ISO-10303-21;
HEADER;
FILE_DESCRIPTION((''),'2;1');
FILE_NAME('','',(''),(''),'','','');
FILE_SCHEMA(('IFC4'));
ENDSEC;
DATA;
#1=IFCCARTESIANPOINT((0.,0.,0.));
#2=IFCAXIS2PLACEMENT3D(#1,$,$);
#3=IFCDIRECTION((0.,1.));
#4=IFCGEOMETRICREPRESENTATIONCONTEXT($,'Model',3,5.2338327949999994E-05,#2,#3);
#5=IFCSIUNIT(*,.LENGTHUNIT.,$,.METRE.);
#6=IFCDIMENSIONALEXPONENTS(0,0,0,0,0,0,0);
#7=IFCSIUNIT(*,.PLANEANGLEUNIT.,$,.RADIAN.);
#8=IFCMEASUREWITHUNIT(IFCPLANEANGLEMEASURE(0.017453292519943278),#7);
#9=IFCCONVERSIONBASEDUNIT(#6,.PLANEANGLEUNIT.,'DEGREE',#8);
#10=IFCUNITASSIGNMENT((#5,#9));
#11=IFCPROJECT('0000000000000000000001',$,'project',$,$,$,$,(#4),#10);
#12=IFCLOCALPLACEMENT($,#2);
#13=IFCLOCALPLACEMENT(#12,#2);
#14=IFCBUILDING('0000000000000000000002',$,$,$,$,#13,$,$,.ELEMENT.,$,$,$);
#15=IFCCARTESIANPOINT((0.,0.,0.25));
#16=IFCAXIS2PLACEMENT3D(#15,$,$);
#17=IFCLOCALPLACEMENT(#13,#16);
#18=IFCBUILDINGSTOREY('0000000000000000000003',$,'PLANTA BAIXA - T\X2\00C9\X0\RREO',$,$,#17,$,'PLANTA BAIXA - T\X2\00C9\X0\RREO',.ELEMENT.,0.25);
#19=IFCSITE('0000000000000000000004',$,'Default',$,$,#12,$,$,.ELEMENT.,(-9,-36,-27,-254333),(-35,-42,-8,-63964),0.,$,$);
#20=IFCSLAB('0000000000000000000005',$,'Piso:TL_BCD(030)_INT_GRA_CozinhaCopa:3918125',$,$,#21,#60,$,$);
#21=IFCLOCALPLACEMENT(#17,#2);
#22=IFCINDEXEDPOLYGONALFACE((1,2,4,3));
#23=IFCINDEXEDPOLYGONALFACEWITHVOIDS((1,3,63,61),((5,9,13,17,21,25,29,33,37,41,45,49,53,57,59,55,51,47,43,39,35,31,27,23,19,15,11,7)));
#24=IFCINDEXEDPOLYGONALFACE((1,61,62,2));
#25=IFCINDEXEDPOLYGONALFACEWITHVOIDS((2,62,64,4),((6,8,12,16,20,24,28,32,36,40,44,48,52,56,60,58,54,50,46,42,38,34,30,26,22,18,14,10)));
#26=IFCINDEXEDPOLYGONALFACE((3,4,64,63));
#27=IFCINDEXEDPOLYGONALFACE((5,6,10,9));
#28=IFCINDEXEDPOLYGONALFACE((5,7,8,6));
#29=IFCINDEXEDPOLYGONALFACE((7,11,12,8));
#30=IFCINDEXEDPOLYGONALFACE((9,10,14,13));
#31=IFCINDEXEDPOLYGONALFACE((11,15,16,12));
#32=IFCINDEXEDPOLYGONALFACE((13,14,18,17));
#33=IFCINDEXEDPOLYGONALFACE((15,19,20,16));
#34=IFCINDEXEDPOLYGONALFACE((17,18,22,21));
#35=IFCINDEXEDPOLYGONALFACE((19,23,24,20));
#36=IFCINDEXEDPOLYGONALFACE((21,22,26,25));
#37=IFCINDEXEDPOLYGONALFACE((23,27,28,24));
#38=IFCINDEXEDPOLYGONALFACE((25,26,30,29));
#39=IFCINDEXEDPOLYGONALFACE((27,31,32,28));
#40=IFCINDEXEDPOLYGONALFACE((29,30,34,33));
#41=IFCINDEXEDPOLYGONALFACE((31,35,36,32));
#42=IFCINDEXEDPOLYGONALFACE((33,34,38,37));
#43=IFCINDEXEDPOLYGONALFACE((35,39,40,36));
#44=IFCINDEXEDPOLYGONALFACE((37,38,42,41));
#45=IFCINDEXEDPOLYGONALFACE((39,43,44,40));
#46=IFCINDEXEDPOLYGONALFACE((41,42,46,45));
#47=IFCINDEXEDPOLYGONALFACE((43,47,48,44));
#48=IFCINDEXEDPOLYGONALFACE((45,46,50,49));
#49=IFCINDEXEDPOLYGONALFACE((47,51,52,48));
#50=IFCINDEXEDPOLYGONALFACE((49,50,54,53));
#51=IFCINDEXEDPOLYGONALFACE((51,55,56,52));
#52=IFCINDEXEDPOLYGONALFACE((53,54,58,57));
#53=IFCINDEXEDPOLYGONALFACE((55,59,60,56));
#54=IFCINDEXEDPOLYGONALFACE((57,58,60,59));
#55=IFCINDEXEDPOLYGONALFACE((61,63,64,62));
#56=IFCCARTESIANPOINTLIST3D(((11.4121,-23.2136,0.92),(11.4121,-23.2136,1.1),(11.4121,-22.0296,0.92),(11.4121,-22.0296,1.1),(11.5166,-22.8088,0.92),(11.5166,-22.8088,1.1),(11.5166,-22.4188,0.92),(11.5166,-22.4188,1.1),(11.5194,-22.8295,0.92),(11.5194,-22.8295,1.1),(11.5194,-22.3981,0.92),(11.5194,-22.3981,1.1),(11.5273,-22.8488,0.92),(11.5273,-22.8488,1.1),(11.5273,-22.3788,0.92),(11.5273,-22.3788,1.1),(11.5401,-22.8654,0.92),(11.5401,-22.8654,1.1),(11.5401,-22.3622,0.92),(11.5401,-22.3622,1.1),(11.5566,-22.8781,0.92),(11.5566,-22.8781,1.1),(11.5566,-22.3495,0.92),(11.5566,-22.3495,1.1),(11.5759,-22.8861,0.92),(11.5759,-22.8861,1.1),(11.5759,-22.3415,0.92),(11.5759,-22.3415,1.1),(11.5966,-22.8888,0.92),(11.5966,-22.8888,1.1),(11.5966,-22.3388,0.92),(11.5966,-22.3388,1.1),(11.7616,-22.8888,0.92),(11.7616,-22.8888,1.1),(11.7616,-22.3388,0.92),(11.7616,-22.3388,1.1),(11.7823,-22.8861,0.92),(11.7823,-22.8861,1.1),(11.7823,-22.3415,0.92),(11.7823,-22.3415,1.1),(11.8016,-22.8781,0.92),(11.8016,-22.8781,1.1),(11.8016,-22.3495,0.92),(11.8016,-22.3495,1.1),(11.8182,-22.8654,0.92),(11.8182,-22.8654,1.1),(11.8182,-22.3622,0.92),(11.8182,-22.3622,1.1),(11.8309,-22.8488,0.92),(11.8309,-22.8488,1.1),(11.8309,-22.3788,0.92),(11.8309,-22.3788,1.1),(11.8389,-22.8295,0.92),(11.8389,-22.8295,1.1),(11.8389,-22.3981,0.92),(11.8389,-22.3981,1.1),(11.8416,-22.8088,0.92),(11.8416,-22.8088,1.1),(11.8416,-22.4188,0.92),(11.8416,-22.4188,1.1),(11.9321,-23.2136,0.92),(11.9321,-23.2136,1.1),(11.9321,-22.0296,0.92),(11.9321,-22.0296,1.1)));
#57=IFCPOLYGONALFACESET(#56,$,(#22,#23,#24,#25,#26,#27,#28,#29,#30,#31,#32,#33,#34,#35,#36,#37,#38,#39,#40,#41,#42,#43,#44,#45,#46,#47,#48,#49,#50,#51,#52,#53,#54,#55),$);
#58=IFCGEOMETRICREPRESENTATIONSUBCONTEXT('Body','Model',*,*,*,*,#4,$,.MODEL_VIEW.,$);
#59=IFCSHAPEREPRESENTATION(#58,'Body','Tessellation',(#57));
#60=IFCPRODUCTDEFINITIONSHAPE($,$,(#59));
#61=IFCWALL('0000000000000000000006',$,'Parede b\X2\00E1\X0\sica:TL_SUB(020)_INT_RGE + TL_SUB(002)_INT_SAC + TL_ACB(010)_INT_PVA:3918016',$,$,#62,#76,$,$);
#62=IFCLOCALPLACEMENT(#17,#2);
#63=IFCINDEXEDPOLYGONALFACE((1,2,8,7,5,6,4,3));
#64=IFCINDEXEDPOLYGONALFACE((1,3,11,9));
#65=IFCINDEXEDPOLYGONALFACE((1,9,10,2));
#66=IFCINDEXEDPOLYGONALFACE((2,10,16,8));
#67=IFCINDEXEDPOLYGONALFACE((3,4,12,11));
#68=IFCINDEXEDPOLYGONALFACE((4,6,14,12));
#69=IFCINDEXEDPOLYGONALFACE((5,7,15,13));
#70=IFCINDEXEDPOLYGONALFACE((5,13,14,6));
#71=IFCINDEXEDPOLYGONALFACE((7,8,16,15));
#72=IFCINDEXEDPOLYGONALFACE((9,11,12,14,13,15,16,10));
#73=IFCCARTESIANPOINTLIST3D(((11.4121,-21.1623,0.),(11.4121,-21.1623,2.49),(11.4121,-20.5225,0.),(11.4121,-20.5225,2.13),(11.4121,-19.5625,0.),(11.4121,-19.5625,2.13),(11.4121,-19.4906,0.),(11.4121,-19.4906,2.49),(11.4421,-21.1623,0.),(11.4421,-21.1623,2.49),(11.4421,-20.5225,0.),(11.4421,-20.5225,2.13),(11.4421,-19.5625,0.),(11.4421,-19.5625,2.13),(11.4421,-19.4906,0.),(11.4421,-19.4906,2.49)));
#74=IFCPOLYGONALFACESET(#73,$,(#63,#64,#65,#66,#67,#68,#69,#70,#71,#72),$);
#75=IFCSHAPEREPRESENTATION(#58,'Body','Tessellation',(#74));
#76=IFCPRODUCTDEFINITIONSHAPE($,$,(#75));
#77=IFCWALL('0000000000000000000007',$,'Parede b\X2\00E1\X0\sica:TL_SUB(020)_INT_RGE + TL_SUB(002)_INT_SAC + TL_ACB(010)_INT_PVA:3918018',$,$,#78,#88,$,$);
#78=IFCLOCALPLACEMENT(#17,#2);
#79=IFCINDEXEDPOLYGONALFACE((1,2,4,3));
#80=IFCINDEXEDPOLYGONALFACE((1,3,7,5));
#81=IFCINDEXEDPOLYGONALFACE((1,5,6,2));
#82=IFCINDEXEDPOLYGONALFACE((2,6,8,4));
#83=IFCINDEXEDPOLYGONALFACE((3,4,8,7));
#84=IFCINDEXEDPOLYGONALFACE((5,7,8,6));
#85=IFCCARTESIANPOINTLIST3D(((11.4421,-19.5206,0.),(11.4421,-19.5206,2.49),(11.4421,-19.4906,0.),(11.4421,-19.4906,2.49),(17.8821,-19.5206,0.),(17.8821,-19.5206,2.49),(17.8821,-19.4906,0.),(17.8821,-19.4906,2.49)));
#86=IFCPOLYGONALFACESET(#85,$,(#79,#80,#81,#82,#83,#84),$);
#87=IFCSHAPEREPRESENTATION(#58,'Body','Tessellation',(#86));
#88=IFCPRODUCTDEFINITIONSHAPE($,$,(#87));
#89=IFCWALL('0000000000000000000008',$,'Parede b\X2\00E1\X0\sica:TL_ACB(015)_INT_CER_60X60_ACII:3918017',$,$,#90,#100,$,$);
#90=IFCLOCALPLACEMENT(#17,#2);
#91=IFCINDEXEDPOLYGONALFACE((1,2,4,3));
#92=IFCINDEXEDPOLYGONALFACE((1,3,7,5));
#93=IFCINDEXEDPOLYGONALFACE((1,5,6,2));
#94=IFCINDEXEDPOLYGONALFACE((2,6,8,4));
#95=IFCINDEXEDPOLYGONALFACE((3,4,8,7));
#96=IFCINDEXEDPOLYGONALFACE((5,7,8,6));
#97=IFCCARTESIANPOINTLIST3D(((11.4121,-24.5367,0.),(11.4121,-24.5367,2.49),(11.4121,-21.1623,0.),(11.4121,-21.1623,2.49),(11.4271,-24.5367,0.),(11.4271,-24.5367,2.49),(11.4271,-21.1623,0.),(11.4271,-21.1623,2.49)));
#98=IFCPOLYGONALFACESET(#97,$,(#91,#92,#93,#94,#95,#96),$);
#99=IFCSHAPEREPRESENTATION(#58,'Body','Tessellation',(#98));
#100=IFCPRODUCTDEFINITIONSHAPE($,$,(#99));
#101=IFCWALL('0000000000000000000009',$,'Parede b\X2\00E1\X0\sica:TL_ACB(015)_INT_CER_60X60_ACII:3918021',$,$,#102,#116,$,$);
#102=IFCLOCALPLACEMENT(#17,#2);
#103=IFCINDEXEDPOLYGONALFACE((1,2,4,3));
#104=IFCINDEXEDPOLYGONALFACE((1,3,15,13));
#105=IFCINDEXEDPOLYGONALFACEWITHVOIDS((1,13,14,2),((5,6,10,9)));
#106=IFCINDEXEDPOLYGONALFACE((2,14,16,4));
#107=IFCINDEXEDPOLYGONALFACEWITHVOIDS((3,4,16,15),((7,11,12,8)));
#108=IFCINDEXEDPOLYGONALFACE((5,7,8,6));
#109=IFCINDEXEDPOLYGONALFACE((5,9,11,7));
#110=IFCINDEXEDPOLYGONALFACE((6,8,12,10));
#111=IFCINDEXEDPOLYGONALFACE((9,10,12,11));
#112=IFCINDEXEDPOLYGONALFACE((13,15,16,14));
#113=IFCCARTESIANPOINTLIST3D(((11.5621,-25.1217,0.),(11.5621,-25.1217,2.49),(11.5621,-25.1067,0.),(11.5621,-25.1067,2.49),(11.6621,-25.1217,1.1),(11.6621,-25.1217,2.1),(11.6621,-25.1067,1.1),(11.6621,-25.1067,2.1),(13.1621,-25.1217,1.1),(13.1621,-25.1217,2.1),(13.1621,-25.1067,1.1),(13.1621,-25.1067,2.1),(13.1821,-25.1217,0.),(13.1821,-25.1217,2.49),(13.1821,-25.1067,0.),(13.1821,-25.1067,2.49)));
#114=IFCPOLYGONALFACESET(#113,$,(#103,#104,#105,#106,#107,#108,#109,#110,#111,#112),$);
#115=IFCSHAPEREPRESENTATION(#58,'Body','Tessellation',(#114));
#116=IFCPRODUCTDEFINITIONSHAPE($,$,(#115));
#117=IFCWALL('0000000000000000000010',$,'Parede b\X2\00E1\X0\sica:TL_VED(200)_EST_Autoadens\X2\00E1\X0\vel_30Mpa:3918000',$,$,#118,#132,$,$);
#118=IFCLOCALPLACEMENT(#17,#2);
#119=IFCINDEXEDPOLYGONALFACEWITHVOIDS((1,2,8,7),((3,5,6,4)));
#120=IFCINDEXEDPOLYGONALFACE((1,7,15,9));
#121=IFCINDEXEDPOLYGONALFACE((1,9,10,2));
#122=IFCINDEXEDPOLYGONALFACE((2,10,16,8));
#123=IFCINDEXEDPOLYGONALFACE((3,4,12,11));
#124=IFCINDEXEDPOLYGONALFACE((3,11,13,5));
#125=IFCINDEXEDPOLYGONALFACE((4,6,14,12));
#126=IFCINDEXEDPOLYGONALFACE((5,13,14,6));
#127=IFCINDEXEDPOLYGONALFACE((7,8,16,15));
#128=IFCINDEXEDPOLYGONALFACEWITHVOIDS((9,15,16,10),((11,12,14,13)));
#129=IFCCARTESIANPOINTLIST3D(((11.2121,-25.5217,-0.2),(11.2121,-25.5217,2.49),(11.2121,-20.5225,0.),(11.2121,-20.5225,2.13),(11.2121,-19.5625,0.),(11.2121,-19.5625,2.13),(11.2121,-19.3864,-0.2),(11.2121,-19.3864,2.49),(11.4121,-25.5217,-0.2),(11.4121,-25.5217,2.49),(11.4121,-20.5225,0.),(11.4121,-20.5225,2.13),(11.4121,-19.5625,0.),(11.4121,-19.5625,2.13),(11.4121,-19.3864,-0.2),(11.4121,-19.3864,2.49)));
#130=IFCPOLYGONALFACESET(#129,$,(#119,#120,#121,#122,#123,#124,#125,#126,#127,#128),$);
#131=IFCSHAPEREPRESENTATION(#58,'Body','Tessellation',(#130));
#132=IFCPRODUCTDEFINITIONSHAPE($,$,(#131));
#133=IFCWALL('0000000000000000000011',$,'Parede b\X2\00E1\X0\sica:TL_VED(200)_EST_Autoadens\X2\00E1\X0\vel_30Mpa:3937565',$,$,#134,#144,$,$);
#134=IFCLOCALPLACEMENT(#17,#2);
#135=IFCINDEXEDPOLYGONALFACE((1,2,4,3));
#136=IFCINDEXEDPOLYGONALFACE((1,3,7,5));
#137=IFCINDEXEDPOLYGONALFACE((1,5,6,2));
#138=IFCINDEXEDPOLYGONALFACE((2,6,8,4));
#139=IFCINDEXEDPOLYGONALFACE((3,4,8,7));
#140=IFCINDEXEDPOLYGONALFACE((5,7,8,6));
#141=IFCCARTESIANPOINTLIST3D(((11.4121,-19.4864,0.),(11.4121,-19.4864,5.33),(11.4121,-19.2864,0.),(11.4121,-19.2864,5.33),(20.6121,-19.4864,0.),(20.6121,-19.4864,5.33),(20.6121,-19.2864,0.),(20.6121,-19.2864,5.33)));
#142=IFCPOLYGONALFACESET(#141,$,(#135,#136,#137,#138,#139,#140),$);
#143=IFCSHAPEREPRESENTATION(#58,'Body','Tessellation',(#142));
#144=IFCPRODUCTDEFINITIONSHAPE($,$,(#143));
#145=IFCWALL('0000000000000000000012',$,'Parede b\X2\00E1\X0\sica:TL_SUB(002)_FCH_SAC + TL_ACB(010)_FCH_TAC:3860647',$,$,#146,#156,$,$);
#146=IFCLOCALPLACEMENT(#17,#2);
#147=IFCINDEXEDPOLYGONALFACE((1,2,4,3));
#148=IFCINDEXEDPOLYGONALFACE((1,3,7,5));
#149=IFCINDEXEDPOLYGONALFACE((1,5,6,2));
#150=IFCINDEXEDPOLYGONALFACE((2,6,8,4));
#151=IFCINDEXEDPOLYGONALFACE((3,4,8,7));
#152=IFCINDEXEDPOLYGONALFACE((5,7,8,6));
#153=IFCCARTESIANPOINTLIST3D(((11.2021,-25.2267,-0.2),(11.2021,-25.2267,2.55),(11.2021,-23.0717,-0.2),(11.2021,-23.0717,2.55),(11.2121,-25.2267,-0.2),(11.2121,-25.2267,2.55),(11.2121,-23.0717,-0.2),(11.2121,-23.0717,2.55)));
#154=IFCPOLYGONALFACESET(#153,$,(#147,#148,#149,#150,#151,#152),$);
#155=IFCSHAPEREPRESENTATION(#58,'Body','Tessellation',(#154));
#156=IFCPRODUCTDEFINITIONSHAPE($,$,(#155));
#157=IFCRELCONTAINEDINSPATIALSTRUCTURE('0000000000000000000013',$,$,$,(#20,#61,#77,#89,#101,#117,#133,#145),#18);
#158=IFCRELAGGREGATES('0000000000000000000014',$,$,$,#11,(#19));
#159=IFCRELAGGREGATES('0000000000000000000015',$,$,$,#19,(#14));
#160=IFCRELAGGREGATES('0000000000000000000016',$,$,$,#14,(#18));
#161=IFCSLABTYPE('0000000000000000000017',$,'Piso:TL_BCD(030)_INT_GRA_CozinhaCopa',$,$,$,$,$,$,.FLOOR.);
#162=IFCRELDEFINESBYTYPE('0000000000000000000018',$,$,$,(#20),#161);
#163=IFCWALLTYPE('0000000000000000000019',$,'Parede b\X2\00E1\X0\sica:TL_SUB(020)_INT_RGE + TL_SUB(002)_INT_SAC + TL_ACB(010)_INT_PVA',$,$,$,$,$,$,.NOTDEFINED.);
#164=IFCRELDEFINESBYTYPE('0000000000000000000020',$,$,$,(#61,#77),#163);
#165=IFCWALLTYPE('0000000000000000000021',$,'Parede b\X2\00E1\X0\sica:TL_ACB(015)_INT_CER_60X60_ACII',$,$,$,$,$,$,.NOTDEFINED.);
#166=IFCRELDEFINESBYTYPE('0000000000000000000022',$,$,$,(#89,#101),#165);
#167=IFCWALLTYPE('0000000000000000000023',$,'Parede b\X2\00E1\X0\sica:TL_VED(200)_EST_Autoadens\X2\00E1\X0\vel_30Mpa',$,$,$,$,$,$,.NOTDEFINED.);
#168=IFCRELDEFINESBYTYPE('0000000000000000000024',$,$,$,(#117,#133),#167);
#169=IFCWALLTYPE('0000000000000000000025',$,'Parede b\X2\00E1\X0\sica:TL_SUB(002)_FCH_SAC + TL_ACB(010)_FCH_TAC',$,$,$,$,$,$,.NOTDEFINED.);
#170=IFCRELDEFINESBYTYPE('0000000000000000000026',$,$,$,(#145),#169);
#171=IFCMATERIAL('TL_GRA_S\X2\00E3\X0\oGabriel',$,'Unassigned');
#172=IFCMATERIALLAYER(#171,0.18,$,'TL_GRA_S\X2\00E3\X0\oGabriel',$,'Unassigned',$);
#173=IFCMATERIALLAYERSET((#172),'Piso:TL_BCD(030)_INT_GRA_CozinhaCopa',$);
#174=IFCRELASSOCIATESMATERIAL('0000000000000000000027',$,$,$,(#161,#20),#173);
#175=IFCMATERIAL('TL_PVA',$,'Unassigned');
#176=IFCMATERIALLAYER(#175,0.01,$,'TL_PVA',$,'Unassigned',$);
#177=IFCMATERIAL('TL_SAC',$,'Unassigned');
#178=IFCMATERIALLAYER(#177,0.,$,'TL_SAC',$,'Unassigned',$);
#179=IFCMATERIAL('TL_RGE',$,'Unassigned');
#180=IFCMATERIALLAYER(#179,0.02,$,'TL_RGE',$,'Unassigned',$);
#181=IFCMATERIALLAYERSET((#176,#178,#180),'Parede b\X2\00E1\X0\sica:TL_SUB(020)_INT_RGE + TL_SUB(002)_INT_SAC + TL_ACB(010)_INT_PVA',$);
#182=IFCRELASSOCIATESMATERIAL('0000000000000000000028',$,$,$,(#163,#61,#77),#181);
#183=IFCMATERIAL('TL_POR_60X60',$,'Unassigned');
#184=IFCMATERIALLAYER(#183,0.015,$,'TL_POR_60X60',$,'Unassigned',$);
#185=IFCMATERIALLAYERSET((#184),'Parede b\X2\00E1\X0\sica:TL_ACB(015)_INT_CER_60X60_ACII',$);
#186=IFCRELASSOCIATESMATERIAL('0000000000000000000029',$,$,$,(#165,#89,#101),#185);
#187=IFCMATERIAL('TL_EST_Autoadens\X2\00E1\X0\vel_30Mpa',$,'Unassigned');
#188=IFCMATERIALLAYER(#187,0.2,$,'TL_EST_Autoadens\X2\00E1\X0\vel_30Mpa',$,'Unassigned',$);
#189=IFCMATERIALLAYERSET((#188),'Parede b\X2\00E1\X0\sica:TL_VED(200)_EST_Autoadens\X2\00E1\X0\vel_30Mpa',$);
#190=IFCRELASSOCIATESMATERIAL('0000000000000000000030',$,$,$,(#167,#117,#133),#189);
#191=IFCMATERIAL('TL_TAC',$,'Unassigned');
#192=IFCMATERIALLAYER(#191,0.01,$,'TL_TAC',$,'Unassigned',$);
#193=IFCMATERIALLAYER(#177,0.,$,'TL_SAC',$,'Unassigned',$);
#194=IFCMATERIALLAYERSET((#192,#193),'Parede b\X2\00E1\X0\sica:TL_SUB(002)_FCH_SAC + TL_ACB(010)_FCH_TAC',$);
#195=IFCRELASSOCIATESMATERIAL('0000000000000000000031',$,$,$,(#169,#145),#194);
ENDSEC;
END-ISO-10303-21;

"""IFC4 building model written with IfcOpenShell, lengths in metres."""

from ifc_helpers import new_model, entity, si_unit, converted_unit, direction, frame, frame_2d, origin, place, context, subcontext, project, spatial, polyline, circle_curve, parameter, trimmed, segment, composite_curve, rectangle, outline, extrude, material, layer, layer_set, layer_usage, type_object, element, save


model = new_model("IFC4")

# Units and contexts
model_context = context("Model", 3, precision=5.2338327949999994e-05, world=origin(), true_north=direction((0.0, 1.0)))
body_context = subcontext(model_context, "Body", "Model", "MODEL_VIEW")
ifc_project = project(units=[si_unit("LENGTHUNIT", "METRE"), converted_unit("PLANEANGLEUNIT", "DEGREE", entity("IfcPlaneAngleMeasure", 0.017453292519943278), si_unit("PLANEANGLEUNIT", "RADIAN"), dimensions=[0, 0, 0, 0, 0, 0, 0])], contexts=[model_context])

# Site, building, storey
site_placement = place(None, frame((0.0, 0.0, 0.0)))
site = spatial("IfcSite", under=ifc_project, at=site_placement, Name="Default", CompositionType="ELEMENT", RefLatitude=(-9, -36, -27, -254333), RefLongitude=(-35, -42, -8, -63964), RefElevation=0.0)
building_placement = place(site_placement, origin())
building = spatial("IfcBuilding", under=site, at=building_placement, CompositionType="ELEMENT")
storey_placement = place(building_placement, frame((0.0, 0.0, 0.25)))
storey = spatial("IfcBuildingStorey", under=building, at=storey_placement, Name="PLANTA BAIXA - TÉRREO", LongName="PLANTA BAIXA - TÉRREO", CompositionType="ELEMENT", Elevation=0.25)

# Shared definitions
ifc_material_1 = material(Name="TL_POR_60X60", Category="Unassigned")

# Slab, opening
ifc_material_2 = material(Name="TL_GRA_SãoGabriel", Category="Unassigned")
ifc_layer_1 = layer(ifc_material_2, 0.18, Name="TL_GRA_SãoGabriel", Category="Unassigned")
ifc_layer_set_1 = layer_set([ifc_layer_1], Name="Piso:TL_BCD(030)_INT_GRA_CozinhaCopa")
ifc_layer_usage_1 = layer_usage(ifc_layer_set_1, "AXIS3", "POSITIVE", 0.0)
slab_type_1 = type_object("IfcSlabType", Name="Piso:TL_BCD(030)_INT_GRA_CozinhaCopa", PredefinedType="FLOOR", material=ifc_layer_set_1)
slab_1_placement = place(storey_placement, frame((11.4121, -23.2136, 0.92)))
slab_1 = element("IfcSlab", 1, at=slab_1_placement, inside=storey, type_object=slab_type_1, material=ifc_layer_usage_1, Name="Piso:TL_BCD(030)_INT_GRA_CozinhaCopa:3918125", context=body_context, shape_type="SweptSolid", body=[
    extrude(rectangle(XDim=1.184, YDim=0.52, at=frame_2d((0.0, 0.0), x_axis=(0.0, 1.0))), frame((0.26, 0.592, 0.18), z_axis=(0.0, 0.0, -1.0), x_axis=(-1.0, 0.0, 0.0)), (0.0, 0.0, 1.0), 0.18),
])
opening_1_placement = place(slab_1_placement, frame((-11.4121, 23.2136, 0.18)))
element("IfcOpeningElement", 2, at=opening_1_placement, cuts=slab_1, PredefinedType="OPENING", context=body_context, shape_type="SweptSolid", body=[
    extrude(outline(composite_curve([segment(polyline([(-0.195, -0.1625), (0.195, -0.1625)]), True, "CONTINUOUS"), segment(trimmed(circle_curve(frame_2d((0.195, -0.0825), x_axis=(-1.0, 0.0)), 0.08), [parameter(90.0)], [parameter(180.0)], True, "PARAMETER"), True, "CONTINUOUS"), segment(polyline([(0.275, -0.0825), (0.275, 0.0825)]), True, "CONTINUOUS"), segment(trimmed(circle_curve(frame_2d((0.195, 0.0825), x_axis=(-1.0, 0.0)), 0.08), [parameter(180.0)], [parameter(270.0)], True, "PARAMETER"), True, "CONTINUOUS"), segment(polyline([(0.195, 0.1625), (-0.195, 0.1625)]), True, "CONTINUOUS"), segment(trimmed(circle_curve(frame_2d((-0.195, 0.0825), x_axis=(-1.0, 0.0)), 0.08), [parameter(270.0)], [parameter(360.0)], True, "PARAMETER"), True, "CONTINUOUS"), segment(polyline([(-0.275, 0.0825), (-0.275, -0.0825)]), True, "CONTINUOUS"), segment(trimmed(circle_curve(frame_2d((-0.195, -0.0825), x_axis=(-1.0, 0.0)), 0.08), [parameter(360.0)], [parameter(90.0)], True, "PARAMETER"), True, "CONTINUOUS")], self_intersect=False)), frame((11.6791, -22.6138, -0.21), z_axis=(0.0, 0.0, 1.0), x_axis=(0.0, -1.0, 0.0)), (0.0, 0.0, 1.0), 0.21),
])

# Wall, opening
ifc_material_3 = material(Name="TL_PVA", Category="Unassigned")
ifc_layer_2 = layer(ifc_material_3, 0.01, Name="TL_PVA", Category="Unassigned")
ifc_material_4 = material(Name="TL_SAC", Category="Unassigned")
ifc_layer_3 = layer(ifc_material_4, 0.0, Name="TL_SAC", Category="Unassigned")
ifc_material_5 = material(Name="TL_RGE", Category="Unassigned")
ifc_layer_4 = layer(ifc_material_5, 0.02, Name="TL_RGE", Category="Unassigned")
ifc_layer_set_2 = layer_set([ifc_layer_2, ifc_layer_3, ifc_layer_4], Name="Parede básica:TL_SUB(020)_INT_RGE + TL_SUB(002)_INT_SAC + TL_ACB(010)_INT_PVA")
ifc_layer_usage_2 = layer_usage(ifc_layer_set_2, "AXIS2", "NEGATIVE", 0.015)
wall_type_1 = type_object("IfcWallType", Name="Parede básica:TL_SUB(020)_INT_RGE + TL_SUB(002)_INT_SAC + TL_ACB(010)_INT_PVA", PredefinedType="NOTDEFINED", material=ifc_layer_set_2)
wall_1_placement = place(storey_placement, frame((11.4271, -19.4906, 0.0), z_axis=(0.0, 0.0, 1.0), x_axis=(0.0, -1.0, 0.0)))
wall_1 = element("IfcWall", 3, at=wall_1_placement, inside=storey, type_object=wall_type_1, material=ifc_layer_usage_2, Name="Parede básica:TL_SUB(020)_INT_RGE + TL_SUB(002)_INT_SAC + TL_ACB(010)_INT_PVA:3918016", context=body_context, shape_type="SweptSolid", body=[
    extrude(rectangle(XDim=1.6717, YDim=0.03, at=frame_2d((0.8359, 0.0), x_axis=(-1.0, 0.0))), origin(), (0.0, 0.0, 1.0), 2.49),
])
opening_2_placement = place(wall_1_placement, frame((-19.4906, -11.4271, 0.0)))
element("IfcOpeningElement", 4, at=opening_2_placement, cuts=wall_1, PredefinedType="OPENING", context=body_context, shape_type="SweptSolid", body=[
    extrude(rectangle(XDim=2.13, YDim=0.96, at=frame_2d((0.0, 0.0), x_axis=(0.0, 1.0))), frame((20.0425, 9.8881, 1.065), z_axis=(0.0, 1.0, 0.0), x_axis=(-1.0, 0.0, 0.0)), (0.0, 0.0, 1.0), 3.048),
])

# Walls
ifc_layer_usage_3 = layer_usage(ifc_layer_set_2, "AXIS2", "POSITIVE", -0.015)
wall_2_placement = place(storey_placement, frame((11.4421, -19.5056, 0.0)))
element("IfcWall", 5, at=wall_2_placement, inside=storey, type_object=wall_type_1, material=ifc_layer_usage_3, Name="Parede básica:TL_SUB(020)_INT_RGE + TL_SUB(002)_INT_SAC + TL_ACB(010)_INT_PVA:3918018", context=body_context, shape_type="SweptSolid", body=[
    extrude(rectangle(XDim=6.44, YDim=0.03, at=frame_2d((3.22, 0.0), x_axis=(-1.0, 0.0))), origin(), (0.0, 0.0, 1.0), 2.49),
])
ifc_layer_5 = layer(ifc_material_1, 0.015, Name="TL_POR_60X60", Category="Unassigned")
ifc_layer_set_3 = layer_set([ifc_layer_5], Name="Parede básica:TL_ACB(015)_INT_CER_60X60_ACII")
ifc_layer_usage_4 = layer_usage(ifc_layer_set_3, "AXIS2", "NEGATIVE", 0.0075)
wall_type_2 = type_object("IfcWallType", Name="Parede básica:TL_ACB(015)_INT_CER_60X60_ACII", PredefinedType="NOTDEFINED", material=ifc_layer_set_3)
wall_3_placement = place(storey_placement, frame((11.4196, -21.1623, 0.0), z_axis=(0.0, 0.0, 1.0), x_axis=(0.0, -1.0, 0.0)))
element("IfcWall", 6, at=wall_3_placement, inside=storey, type_object=wall_type_2, material=ifc_layer_usage_4, Name="Parede básica:TL_ACB(015)_INT_CER_60X60_ACII:3918017", context=body_context, shape_type="SweptSolid", body=[
    extrude(rectangle(XDim=3.3744, YDim=0.015, at=frame_2d((1.6872, 0.0), x_axis=(-1.0, 0.0))), origin(), (0.0, 0.0, 1.0), 2.49),
])

# Walls, openings
ifc_layer_usage_5 = layer_usage(ifc_layer_set_3, "AXIS2", "NEGATIVE", 0.0075)
wall_4_placement = place(storey_placement, frame((11.5621, -25.1142, 0.0)))
wall_4 = element("IfcWall", 7, at=wall_4_placement, inside=storey, type_object=wall_type_2, material=ifc_layer_usage_5, Name="Parede básica:TL_ACB(015)_INT_CER_60X60_ACII:3918021", context=body_context, shape_type="SweptSolid", body=[
    extrude(rectangle(XDim=1.62, YDim=0.015, at=frame_2d((0.81, 0.0), x_axis=(-1.0, 0.0))), origin(), (0.0, 0.0, 1.0), 2.49),
])
opening_3_placement = place(wall_4_placement, frame((-11.5621, 25.1142, 1.1)))
element("IfcOpeningElement", 8, at=opening_3_placement, cuts=wall_4, PredefinedType="OPENING", context=body_context, shape_type="SweptSolid", body=[
    extrude(rectangle(XDim=1.0, YDim=1.5, at=frame_2d((0.0, 0.0), x_axis=(0.0, 1.0))), frame((12.4121, -26.6457, 0.5), z_axis=(0.0, 1.0, 0.0), x_axis=(1.0, 0.0, 0.0)), (0.0, 0.0, 1.0), 3.048),
])
ifc_material_6 = material(Name="TL_EST_Autoadensável_30Mpa", Category="Unassigned")
ifc_layer_6 = layer(ifc_material_6, 0.2, Name="TL_EST_Autoadensável_30Mpa", Category="Unassigned")
ifc_layer_set_4 = layer_set([ifc_layer_6], Name="Parede básica:TL_VED(200)_EST_Autoadensável_30Mpa")
ifc_layer_usage_6 = layer_usage(ifc_layer_set_4, "AXIS2", "NEGATIVE", 0.1)
wall_type_3 = type_object("IfcWallType", Name="Parede básica:TL_VED(200)_EST_Autoadensável_30Mpa", PredefinedType="NOTDEFINED", material=ifc_layer_set_4)
wall_5_placement = place(storey_placement, frame((11.3121, -25.5217, -0.2), z_axis=(0.0, 0.0, 1.0), x_axis=(0.0, 1.0, 0.0)))
wall_5 = element("IfcWall", 9, at=wall_5_placement, inside=storey, type_object=wall_type_3, material=ifc_layer_usage_6, Name="Parede básica:TL_VED(200)_EST_Autoadensável_30Mpa:3918000", context=body_context, shape_type="SweptSolid", body=[
    extrude(rectangle(XDim=6.1354, YDim=0.2, at=frame_2d((3.0677, 0.0), x_axis=(-1.0, 0.0))), origin(), (0.0, 0.0, 1.0), 2.69),
])
opening_4_placement = place(wall_5_placement, frame((5.9592, 0.1, 0.2)))
element("IfcOpeningElement", 10, at=opening_4_placement, cuts=wall_5, PredefinedType="OPENING", context=body_context, shape_type="SweptSolid", body=[
    extrude(rectangle(XDim=2.13, YDim=0.96, at=frame_2d((1.065, 0.48), x_axis=(1.0, 0.0))), frame((0.0, 0.0, 0.0), z_axis=(0.0, -1.0, 0.0), x_axis=(0.0, 0.0, 1.0)), (0.0, 0.0, 1.0), 0.2),
])

# Walls
ifc_layer_usage_7 = layer_usage(ifc_layer_set_4, "AXIS2", "POSITIVE", -0.1)
wall_6_placement = place(storey_placement, frame((11.4121, -19.3864, 0.0)))
element("IfcWall", 11, at=wall_6_placement, inside=storey, type_object=wall_type_3, material=ifc_layer_usage_7, Name="Parede básica:TL_VED(200)_EST_Autoadensável_30Mpa:3937565", context=body_context, shape_type="SweptSolid", body=[
    extrude(rectangle(XDim=9.2, YDim=0.2, at=frame_2d((4.6, 0.0), x_axis=(-1.0, 0.0))), origin(), (0.0, 0.0, 1.0), 5.33),
])
ifc_material_7 = material(Name="TL_TAC", Category="Unassigned")
ifc_layer_7 = layer(ifc_material_7, 0.01, Name="TL_TAC", Category="Unassigned")
ifc_layer_8 = layer(ifc_material_4, 0.0, Name="TL_SAC", Category="Unassigned")
ifc_layer_set_5 = layer_set([ifc_layer_7, ifc_layer_8], Name="Parede básica:TL_SUB(002)_FCH_SAC + TL_ACB(010)_FCH_TAC")
ifc_layer_usage_8 = layer_usage(ifc_layer_set_5, "AXIS2", "NEGATIVE", 0.005)
wall_type_4 = type_object("IfcWallType", Name="Parede básica:TL_SUB(002)_FCH_SAC + TL_ACB(010)_FCH_TAC", PredefinedType="NOTDEFINED", material=ifc_layer_set_5)
wall_7_placement = place(storey_placement, frame((11.2071, -23.0717, -0.2), z_axis=(0.0, 0.0, 1.0), x_axis=(0.0, -1.0, 0.0)))
element("IfcWall", 12, at=wall_7_placement, inside=storey, type_object=wall_type_4, material=ifc_layer_usage_8, Name="Parede básica:TL_SUB(002)_FCH_SAC + TL_ACB(010)_FCH_TAC:3860647", context=body_context, shape_type="SweptSolid", body=[
    extrude(rectangle(XDim=2.155, YDim=0.01, at=frame_2d((1.0775, 0.0), x_axis=(-1.0, 0.0))), origin(), (0.0, 0.0, 1.0), 2.75),
])

save(model, "model.ifc")
